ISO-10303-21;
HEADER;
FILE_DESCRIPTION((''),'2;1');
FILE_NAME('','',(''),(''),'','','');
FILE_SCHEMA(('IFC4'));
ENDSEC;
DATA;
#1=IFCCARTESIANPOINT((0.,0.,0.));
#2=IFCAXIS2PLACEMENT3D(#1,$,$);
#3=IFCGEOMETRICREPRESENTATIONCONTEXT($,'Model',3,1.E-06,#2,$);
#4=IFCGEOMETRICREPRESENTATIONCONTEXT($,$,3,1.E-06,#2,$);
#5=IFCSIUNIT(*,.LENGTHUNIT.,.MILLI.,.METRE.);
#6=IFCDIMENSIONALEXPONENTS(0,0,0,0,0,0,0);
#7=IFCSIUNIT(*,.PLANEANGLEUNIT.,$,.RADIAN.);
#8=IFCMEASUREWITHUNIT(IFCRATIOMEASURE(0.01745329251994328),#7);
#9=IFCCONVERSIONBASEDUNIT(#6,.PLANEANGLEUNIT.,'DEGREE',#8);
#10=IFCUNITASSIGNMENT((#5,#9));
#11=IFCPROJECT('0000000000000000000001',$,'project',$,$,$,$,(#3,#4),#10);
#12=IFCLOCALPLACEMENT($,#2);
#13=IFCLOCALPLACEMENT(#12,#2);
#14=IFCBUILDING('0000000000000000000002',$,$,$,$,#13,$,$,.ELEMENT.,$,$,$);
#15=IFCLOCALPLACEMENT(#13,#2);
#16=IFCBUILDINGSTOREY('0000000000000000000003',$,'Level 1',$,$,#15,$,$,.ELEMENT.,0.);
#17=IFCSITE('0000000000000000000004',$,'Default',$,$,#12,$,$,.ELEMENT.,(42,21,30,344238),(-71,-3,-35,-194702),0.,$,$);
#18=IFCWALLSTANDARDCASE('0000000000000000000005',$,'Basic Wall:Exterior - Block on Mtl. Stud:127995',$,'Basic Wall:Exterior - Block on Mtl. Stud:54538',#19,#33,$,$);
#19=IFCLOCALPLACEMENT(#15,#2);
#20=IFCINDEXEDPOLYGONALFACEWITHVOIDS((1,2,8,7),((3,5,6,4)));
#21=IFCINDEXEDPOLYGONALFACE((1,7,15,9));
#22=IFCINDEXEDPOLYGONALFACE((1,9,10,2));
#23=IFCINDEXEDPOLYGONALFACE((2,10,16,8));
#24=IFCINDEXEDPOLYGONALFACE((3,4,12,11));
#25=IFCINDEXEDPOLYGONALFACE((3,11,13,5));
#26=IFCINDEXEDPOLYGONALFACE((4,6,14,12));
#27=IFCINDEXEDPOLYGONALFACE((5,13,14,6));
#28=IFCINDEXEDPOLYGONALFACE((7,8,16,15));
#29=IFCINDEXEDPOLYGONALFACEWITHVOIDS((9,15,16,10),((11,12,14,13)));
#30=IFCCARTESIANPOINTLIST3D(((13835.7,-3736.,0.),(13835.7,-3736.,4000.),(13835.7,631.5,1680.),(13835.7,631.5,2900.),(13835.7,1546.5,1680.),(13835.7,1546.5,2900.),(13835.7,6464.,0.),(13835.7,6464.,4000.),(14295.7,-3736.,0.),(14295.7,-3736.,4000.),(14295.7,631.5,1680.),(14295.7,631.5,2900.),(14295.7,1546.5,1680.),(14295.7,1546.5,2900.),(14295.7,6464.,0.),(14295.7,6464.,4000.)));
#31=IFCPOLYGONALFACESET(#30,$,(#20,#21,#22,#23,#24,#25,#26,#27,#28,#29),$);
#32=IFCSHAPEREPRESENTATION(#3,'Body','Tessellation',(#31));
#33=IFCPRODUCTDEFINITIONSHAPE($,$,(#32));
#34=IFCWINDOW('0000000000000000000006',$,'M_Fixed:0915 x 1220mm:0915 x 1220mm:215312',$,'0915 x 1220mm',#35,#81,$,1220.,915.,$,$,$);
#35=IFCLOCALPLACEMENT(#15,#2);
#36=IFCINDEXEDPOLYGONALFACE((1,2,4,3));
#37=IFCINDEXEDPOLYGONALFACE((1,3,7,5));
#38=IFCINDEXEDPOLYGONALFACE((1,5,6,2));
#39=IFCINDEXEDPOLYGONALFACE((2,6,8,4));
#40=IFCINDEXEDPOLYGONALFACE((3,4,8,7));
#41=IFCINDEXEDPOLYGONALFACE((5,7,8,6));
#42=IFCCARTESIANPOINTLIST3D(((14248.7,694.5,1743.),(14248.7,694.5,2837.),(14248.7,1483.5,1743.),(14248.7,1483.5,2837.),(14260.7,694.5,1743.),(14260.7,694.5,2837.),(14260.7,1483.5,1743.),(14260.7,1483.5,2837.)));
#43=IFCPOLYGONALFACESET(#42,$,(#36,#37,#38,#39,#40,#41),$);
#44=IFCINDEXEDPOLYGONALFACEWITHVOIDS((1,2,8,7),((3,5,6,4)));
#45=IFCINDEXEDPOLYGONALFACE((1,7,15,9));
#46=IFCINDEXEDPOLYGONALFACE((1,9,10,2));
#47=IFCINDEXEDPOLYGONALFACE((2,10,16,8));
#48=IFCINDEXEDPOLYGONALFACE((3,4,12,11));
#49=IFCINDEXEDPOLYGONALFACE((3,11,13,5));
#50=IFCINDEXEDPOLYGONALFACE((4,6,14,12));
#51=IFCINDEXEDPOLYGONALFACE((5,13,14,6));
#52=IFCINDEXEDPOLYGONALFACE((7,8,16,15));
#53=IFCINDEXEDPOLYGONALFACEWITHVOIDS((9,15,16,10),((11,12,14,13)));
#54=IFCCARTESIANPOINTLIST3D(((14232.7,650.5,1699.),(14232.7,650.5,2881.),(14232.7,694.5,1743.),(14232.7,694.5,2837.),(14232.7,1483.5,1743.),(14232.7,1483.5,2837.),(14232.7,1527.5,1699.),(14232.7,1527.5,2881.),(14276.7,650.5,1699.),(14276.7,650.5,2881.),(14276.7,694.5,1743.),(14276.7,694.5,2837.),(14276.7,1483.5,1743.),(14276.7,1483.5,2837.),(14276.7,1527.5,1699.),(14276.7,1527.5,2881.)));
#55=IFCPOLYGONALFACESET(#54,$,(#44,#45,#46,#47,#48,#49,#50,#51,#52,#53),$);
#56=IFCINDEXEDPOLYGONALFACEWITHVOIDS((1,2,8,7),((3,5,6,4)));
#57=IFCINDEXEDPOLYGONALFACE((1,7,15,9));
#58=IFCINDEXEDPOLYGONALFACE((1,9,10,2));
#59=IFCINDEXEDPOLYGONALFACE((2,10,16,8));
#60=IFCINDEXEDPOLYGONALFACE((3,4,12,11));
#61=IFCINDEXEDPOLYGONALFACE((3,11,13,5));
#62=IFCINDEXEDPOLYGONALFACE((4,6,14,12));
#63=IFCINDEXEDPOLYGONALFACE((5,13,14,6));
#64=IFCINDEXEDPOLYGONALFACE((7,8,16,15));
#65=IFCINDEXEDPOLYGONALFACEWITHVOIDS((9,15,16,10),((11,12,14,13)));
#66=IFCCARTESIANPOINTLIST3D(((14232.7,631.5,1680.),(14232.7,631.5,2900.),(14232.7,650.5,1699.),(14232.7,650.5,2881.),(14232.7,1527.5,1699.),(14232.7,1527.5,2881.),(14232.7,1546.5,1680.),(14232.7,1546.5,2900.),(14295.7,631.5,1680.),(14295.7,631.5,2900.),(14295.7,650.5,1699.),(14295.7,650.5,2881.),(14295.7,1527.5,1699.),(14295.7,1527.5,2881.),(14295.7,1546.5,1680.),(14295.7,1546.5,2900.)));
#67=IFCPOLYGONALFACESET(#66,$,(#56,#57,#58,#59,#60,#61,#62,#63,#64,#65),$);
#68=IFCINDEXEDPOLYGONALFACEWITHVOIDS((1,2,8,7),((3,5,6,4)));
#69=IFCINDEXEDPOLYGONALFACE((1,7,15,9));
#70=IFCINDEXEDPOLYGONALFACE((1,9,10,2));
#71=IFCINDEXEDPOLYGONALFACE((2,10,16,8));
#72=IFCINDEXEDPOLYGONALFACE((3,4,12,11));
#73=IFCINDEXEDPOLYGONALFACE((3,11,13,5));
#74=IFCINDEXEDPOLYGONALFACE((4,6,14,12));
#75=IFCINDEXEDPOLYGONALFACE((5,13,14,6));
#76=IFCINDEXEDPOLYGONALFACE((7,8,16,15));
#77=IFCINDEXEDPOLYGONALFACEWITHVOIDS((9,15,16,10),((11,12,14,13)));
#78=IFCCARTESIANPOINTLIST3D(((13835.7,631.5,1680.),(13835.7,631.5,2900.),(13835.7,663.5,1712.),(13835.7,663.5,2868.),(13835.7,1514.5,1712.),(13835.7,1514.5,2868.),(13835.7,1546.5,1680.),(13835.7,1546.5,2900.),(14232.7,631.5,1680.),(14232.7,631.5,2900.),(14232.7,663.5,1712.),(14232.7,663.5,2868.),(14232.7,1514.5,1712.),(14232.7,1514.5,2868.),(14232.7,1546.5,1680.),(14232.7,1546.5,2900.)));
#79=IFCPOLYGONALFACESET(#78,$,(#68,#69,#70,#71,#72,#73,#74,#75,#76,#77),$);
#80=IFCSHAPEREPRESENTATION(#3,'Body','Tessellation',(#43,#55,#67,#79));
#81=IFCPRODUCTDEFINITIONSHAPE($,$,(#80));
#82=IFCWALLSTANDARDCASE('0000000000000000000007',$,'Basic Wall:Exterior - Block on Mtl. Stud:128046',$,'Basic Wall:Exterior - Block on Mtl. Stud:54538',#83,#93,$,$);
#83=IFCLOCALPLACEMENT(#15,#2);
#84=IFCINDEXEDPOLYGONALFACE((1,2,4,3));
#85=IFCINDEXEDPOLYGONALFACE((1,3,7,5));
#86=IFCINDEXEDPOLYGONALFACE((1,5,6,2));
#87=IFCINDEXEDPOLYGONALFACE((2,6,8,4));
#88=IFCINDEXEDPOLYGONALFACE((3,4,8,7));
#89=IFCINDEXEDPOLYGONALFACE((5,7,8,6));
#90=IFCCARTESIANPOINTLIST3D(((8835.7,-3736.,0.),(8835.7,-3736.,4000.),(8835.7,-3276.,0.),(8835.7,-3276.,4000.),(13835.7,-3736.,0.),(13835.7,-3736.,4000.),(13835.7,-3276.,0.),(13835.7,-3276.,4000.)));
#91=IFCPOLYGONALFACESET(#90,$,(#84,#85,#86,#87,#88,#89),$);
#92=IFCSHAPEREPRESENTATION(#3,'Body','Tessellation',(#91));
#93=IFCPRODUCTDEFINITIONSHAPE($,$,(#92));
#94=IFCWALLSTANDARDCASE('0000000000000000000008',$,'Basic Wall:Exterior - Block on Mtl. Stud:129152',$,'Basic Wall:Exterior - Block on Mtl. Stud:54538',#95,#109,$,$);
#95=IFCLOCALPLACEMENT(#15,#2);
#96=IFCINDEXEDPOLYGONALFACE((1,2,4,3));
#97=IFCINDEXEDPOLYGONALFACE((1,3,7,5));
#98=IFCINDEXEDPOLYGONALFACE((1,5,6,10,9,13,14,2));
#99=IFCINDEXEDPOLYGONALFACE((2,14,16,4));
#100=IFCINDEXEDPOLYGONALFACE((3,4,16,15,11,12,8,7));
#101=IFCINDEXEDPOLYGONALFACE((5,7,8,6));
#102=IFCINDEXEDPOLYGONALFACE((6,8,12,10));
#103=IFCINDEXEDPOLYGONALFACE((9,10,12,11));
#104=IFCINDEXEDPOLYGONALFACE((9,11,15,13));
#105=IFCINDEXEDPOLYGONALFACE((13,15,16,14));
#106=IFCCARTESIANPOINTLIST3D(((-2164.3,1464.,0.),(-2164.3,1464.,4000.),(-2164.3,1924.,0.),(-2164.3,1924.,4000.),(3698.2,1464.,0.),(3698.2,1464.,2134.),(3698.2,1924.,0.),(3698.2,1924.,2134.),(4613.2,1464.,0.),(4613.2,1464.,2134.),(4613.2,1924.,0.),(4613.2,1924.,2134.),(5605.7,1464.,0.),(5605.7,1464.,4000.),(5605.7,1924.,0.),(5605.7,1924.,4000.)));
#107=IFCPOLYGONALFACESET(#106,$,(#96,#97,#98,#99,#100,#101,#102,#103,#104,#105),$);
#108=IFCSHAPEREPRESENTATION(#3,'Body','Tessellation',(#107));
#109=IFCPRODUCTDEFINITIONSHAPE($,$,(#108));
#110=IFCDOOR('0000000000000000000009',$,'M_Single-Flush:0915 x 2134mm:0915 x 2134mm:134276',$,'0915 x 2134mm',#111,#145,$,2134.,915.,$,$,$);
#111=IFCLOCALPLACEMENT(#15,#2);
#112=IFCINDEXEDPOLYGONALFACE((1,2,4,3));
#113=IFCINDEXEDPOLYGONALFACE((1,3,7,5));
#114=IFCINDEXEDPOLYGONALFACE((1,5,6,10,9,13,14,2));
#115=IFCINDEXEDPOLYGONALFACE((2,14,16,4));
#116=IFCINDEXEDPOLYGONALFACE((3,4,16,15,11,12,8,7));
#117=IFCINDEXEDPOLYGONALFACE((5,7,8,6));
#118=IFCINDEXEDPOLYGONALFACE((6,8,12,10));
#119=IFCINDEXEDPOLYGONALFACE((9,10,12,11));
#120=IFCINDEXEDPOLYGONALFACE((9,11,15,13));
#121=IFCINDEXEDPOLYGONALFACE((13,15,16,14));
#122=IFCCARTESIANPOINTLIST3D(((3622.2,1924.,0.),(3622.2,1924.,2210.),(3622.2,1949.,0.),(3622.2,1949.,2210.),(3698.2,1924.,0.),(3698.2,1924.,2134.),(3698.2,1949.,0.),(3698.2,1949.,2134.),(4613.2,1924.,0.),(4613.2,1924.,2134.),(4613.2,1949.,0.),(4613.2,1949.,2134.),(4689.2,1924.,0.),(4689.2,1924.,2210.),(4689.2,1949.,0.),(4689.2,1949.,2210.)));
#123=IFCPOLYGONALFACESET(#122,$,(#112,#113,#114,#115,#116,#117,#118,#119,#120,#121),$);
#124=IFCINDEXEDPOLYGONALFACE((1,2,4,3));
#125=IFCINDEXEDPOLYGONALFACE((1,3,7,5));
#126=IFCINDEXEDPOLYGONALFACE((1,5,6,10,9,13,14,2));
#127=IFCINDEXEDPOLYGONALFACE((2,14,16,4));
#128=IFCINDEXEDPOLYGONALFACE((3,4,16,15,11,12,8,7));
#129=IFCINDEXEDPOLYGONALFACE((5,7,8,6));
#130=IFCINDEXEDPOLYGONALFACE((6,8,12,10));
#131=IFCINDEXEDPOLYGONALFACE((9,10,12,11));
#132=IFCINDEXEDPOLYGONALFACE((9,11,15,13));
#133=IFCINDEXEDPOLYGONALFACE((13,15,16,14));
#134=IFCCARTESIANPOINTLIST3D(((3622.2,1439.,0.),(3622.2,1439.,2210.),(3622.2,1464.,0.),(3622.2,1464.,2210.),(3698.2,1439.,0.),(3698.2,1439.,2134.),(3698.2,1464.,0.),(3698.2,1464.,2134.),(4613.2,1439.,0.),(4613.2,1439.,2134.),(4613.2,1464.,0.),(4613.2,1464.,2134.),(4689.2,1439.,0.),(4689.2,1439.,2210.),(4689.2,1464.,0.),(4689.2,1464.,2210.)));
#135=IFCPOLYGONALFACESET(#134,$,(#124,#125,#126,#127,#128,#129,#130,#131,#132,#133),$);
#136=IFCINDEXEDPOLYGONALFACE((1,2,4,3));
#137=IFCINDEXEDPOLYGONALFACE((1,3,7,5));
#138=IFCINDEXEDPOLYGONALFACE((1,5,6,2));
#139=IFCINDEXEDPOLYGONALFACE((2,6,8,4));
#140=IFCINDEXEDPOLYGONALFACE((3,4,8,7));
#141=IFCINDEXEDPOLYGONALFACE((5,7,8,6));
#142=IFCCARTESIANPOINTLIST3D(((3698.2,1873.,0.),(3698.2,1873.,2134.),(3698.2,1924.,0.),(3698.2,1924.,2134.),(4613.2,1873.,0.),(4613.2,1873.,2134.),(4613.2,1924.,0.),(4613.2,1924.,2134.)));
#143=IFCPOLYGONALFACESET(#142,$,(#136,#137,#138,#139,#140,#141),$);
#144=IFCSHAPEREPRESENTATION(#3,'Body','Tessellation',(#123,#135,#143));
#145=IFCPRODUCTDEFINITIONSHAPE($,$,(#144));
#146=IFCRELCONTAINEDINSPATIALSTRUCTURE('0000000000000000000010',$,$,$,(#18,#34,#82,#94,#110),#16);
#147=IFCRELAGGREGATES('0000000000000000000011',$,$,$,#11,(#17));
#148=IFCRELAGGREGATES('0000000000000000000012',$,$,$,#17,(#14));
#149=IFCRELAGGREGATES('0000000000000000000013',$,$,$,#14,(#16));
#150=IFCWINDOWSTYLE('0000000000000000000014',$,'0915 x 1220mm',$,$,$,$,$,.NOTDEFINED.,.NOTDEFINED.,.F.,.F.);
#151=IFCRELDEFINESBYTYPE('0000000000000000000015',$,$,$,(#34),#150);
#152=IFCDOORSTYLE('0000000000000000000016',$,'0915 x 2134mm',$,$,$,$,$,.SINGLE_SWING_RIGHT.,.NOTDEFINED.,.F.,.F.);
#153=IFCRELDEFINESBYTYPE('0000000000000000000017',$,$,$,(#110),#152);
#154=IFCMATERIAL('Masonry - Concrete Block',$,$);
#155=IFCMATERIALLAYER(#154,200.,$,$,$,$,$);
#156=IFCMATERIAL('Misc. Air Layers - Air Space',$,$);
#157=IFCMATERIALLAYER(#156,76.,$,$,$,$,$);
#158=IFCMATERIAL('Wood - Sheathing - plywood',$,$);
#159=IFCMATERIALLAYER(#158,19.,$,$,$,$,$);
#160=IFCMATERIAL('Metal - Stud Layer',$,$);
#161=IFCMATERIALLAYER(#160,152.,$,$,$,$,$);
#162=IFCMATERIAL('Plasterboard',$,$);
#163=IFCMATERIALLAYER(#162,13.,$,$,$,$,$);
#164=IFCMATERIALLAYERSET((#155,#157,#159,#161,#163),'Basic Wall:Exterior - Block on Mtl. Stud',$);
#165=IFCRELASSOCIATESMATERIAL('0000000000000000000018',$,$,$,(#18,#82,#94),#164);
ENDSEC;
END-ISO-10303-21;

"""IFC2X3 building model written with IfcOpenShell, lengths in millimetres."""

from ifc_helpers import new_model, entity, si_unit, converted_unit, frame, frame_2d, origin, origin_2d_with_axis, place, context, project, spatial, polyline, rectangle, outline, extrude, source, transform, mapped, material, layer, layer_set, layer_usage, type_object, type_shapes, element, fill, save


model = new_model("IFC2X3")

# Units and contexts
model_context = context("Model", 3, precision=1e-06, world=origin())
context_of_model = context(None, 3, precision=1e-06, world=origin())
ifc_project = project(units=[si_unit("LENGTHUNIT", "METRE", prefix="MILLI"), converted_unit("PLANEANGLEUNIT", "DEGREE", entity("IfcRatioMeasure", 0.01745329251994328), si_unit("PLANEANGLEUNIT", "RADIAN"), dimensions=[0, 0, 0, 0, 0, 0, 0])], contexts=[model_context, context_of_model])

# Site, building, storey
site_placement = place(None, origin())
site = spatial("IfcSite", under=ifc_project, at=site_placement, Name="Default", CompositionType="ELEMENT", RefLatitude=(42, 21, 30, 344238), RefLongitude=(-71, -3, -35, -194702), RefElevation=0.0)
building_placement = place(site_placement, origin())
building = spatial("IfcBuilding", under=site, at=building_placement, CompositionType="ELEMENT")
storey_placement = place(building_placement, origin())
storey = spatial("IfcBuildingStorey", under=building, at=storey_placement, Name="Level 1", CompositionType="ELEMENT", Elevation=0.0)

# Shared definitions
ifc_material_1 = material(Name="Masonry - Concrete Block")
ifc_layer_1 = layer(ifc_material_1, 200.0)
ifc_material_2 = material(Name="Misc. Air Layers - Air Space")
ifc_layer_2 = layer(ifc_material_2, 76.0)
ifc_material_3 = material(Name="Wood - Sheathing - plywood")
ifc_layer_3 = layer(ifc_material_3, 19.0)
ifc_material_4 = material(Name="Metal - Stud Layer")
ifc_layer_4 = layer(ifc_material_4, 152.0)
ifc_material_5 = material(Name="Plasterboard")
ifc_layer_5 = layer(ifc_material_5, 13.0)
ifc_layer_set_1 = layer_set([ifc_layer_1, ifc_layer_2, ifc_layer_3, ifc_layer_4, ifc_layer_5], Name="Basic Wall:Exterior - Block on Mtl. Stud")

# Wall, opening, window
ifc_layer_usage_1 = layer_usage(ifc_layer_set_1, "AXIS2", "NEGATIVE", 230.0)
wall_1_placement = place(storey_placement, frame((14065.7, 6464.0, 0.0), z_axis=(0.0, 0.0, 1.0), x_axis=(0.0, -1.0, 0.0)))
wall_1 = element("IfcWallStandardCase", 1, at=wall_1_placement, inside=storey, material=ifc_layer_usage_1, Name="Basic Wall:Exterior - Block on Mtl. Stud:127995", ObjectType="Basic Wall:Exterior - Block on Mtl. Stud:54538", context=model_context, shape_type="SweptSolid", body=[
    extrude(rectangle(XDim=10200.0, YDim=460.0, at=frame_2d((5100.0, 0.0), x_axis=(-1.0, 0.0))), origin(), (0.0, 0.0, 1.0), 4000.0),
])
opening_1_placement = place(wall_1_placement, frame((4917.5, -230.0, 1680.0)))
opening_1 = element("IfcOpeningElement", 2, at=opening_1_placement, cuts=wall_1, ObjectType="Opening", context=model_context, shape_type="SweptSolid", body=[
    extrude(rectangle(XDim=1220.0, YDim=915.0, at=frame_2d((610.0, 457.5), x_axis=(1.0, 0.0))), frame((0.0, 0.0, 0.0), z_axis=(0.0, 1.0, 0.0), x_axis=(0.0, 0.0, 1.0)), (0.0, 0.0, 1.0), 460.0),
])
window_style_1 = type_object("IfcWindowStyle", Name="0915 x 1220mm", ConstructionType="NOTDEFINED", OperationType="NOTDEFINED", ParameterTakesPrecedence=False, Sizeable=False)
shared_shape_1 = source(origin(), model_context, "Body", "SweptSolid", [
    extrude(rectangle(XDim=12.0, YDim=789.0, at=origin_2d_with_axis()), frame((457.5, 419.0, 63.0), z_axis=(0.0, 0.0, 1.0), x_axis=(0.0, -1.0, 0.0)), (0.0, 0.0, 1.0), 1094.0),
    extrude(outline(polyline([(-438.5, -591.0), (438.5, -591.0), (438.5, 591.0), (-438.5, 591.0), (-438.5, -591.0)]), holes=[polyline([(-394.5, -547.0), (-394.5, 547.0), (394.5, 547.0), (394.5, -547.0), (-394.5, -547.0)])]), frame((457.5, 397.0, 610.0), z_axis=(0.0, 1.0, 0.0), x_axis=(1.0, 0.0, 0.0)), (0.0, 0.0, 1.0), 44.0),
    extrude(outline(polyline([(-457.5, -610.0), (457.5, -610.0), (457.5, 610.0), (-457.5, 610.0), (-457.5, -610.0)]), holes=[polyline([(-438.5, -591.0), (-438.5, 591.0), (438.5, 591.0), (438.5, -591.0), (-438.5, -591.0)])]), frame((457.5, 397.0, 610.0), z_axis=(0.0, 1.0, 0.0), x_axis=(1.0, 0.0, 0.0)), (0.0, 0.0, 1.0), 63.0),
    extrude(outline(polyline([(-457.5, -610.0), (457.5, -610.0), (457.5, 610.0), (-457.5, 610.0), (-457.5, -610.0)]), holes=[polyline([(-425.5, -578.0), (-425.5, 578.0), (425.5, 578.0), (425.5, -578.0), (-425.5, -578.0)])]), frame((457.5, 0.0, 610.0), z_axis=(0.0, 1.0, 0.0), x_axis=(1.0, 0.0, 0.0)), (0.0, 0.0, 1.0), 397.0),
])
type_shapes(window_style_1, [shared_shape_1])
window_1_placement = place(opening_1_placement, origin())
window_1 = element("IfcWindow", 3, at=window_1_placement, inside=storey, type_object=window_style_1, Name="M_Fixed:0915 x 1220mm:0915 x 1220mm:215312", ObjectType="0915 x 1220mm", OverallHeight=1220.0, OverallWidth=915.0, context=model_context, shape_type="MappedRepresentation", body=[
    mapped(shared_shape_1, transform((0.0, 0.0, 0.0), scale=1.0)),
])
fill(opening_1, window_1)

# Wall
ifc_layer_usage_2 = layer_usage(ifc_layer_set_1, "AXIS2", "NEGATIVE", 230.0)
wall_2_placement = place(storey_placement, frame((13835.7, -3506.0, 0.0), z_axis=(0.0, 0.0, 1.0), x_axis=(-1.0, 0.0, 0.0)))
element("IfcWallStandardCase", 4, at=wall_2_placement, inside=storey, material=ifc_layer_usage_2, Name="Basic Wall:Exterior - Block on Mtl. Stud:128046", ObjectType="Basic Wall:Exterior - Block on Mtl. Stud:54538", context=model_context, shape_type="SweptSolid", body=[
    extrude(rectangle(XDim=5000.0, YDim=460.0, at=frame_2d((2500.0, 0.0), x_axis=(-1.0, 0.0))), origin(), (0.0, 0.0, 1.0), 4000.0),
])

# Wall, opening, door
ifc_layer_usage_3 = layer_usage(ifc_layer_set_1, "AXIS2", "NEGATIVE", 230.0)
wall_3_placement = place(storey_placement, frame((5605.7, 1694.0, 0.0), z_axis=(0.0, 0.0, 1.0), x_axis=(-1.0, 0.0, 0.0)))
wall_3 = element("IfcWallStandardCase", 5, at=wall_3_placement, inside=storey, material=ifc_layer_usage_3, Name="Basic Wall:Exterior - Block on Mtl. Stud:129152", ObjectType="Basic Wall:Exterior - Block on Mtl. Stud:54538", context=model_context, shape_type="SweptSolid", body=[
    extrude(rectangle(XDim=7770.0, YDim=460.0, at=frame_2d((3885.0, 0.0), x_axis=(-1.0, 0.0))), origin(), (0.0, 0.0, 1.0), 4000.0),
])
opening_2_placement = place(wall_3_placement, frame((1907.5, 230.0, 0.0)))
opening_2 = element("IfcOpeningElement", 6, at=opening_2_placement, cuts=wall_3, ObjectType="Opening", context=model_context, shape_type="SweptSolid", body=[
    extrude(rectangle(XDim=915.0, YDim=2134.0, at=frame_2d((1067.0, 457.5), x_axis=(0.0, 1.0))), frame((0.0, 0.0, 0.0), z_axis=(0.0, -1.0, 0.0), x_axis=(0.0, 0.0, 1.0)), (0.0, 0.0, 1.0), 460.0),
])
door_style_1 = type_object("IfcDoorStyle", Name="0915 x 2134mm", ConstructionType="NOTDEFINED", OperationType="SINGLE_SWING_RIGHT", ParameterTakesPrecedence=False, Sizeable=False)
shared_shape_2 = source(origin(), model_context, "Body", "SweptSolid", [
    extrude(outline(polyline([(-533.5, -1124.0), (533.5, -1124.0), (533.5, 1086.0), (457.5, 1086.0), (457.5, -1048.0), (-457.5, -1048.0), (-457.5, 1086.0), (-533.5, 1086.0), (-533.5, -1124.0)])), frame((457.5, 460.0, 1086.0), z_axis=(0.0, 1.0, 0.0), x_axis=(1.0, 0.0, 0.0)), (0.0, 0.0, 1.0), 25.0),
    extrude(outline(polyline([(-1124.0, -533.5), (1086.0, -533.5), (1086.0, -457.5), (-1048.0, -457.5), (-1048.0, 457.5), (1086.0, 457.5), (1086.0, 533.5), (-1124.0, 533.5), (-1124.0, -533.5)])), frame((457.5, -25.0, 1086.0), z_axis=(0.0, 1.0, 0.0), x_axis=(0.0, 0.0, -1.0)), (0.0, 0.0, 1.0), 25.0),
    extrude(rectangle(XDim=51.0, YDim=915.0, at=origin_2d_with_axis()), frame((457.5, 434.5, 0.0), z_axis=(0.0, 0.0, 1.0), x_axis=(0.0, 1.0, 0.0)), (0.0, 0.0, 1.0), 2134.0),
])
type_shapes(door_style_1, [shared_shape_2])
door_1_placement = place(opening_2_placement, frame((0.0, 0.0, 0.0), z_axis=(0.0, 0.0, 1.0), x_axis=(-1.0, 0.0, 0.0)))
door_1 = element("IfcDoor", 7, at=door_1_placement, inside=storey, type_object=door_style_1, Name="M_Single-Flush:0915 x 2134mm:0915 x 2134mm:134276", ObjectType="0915 x 2134mm", OverallHeight=2134.0, OverallWidth=915.0, context=model_context, shape_type="MappedRepresentation", body=[
    mapped(shared_shape_2, transform((0.0, 0.0, 0.0), scale=1.0)),
])
fill(opening_2, door_1)

save(model, "model.ifc")
